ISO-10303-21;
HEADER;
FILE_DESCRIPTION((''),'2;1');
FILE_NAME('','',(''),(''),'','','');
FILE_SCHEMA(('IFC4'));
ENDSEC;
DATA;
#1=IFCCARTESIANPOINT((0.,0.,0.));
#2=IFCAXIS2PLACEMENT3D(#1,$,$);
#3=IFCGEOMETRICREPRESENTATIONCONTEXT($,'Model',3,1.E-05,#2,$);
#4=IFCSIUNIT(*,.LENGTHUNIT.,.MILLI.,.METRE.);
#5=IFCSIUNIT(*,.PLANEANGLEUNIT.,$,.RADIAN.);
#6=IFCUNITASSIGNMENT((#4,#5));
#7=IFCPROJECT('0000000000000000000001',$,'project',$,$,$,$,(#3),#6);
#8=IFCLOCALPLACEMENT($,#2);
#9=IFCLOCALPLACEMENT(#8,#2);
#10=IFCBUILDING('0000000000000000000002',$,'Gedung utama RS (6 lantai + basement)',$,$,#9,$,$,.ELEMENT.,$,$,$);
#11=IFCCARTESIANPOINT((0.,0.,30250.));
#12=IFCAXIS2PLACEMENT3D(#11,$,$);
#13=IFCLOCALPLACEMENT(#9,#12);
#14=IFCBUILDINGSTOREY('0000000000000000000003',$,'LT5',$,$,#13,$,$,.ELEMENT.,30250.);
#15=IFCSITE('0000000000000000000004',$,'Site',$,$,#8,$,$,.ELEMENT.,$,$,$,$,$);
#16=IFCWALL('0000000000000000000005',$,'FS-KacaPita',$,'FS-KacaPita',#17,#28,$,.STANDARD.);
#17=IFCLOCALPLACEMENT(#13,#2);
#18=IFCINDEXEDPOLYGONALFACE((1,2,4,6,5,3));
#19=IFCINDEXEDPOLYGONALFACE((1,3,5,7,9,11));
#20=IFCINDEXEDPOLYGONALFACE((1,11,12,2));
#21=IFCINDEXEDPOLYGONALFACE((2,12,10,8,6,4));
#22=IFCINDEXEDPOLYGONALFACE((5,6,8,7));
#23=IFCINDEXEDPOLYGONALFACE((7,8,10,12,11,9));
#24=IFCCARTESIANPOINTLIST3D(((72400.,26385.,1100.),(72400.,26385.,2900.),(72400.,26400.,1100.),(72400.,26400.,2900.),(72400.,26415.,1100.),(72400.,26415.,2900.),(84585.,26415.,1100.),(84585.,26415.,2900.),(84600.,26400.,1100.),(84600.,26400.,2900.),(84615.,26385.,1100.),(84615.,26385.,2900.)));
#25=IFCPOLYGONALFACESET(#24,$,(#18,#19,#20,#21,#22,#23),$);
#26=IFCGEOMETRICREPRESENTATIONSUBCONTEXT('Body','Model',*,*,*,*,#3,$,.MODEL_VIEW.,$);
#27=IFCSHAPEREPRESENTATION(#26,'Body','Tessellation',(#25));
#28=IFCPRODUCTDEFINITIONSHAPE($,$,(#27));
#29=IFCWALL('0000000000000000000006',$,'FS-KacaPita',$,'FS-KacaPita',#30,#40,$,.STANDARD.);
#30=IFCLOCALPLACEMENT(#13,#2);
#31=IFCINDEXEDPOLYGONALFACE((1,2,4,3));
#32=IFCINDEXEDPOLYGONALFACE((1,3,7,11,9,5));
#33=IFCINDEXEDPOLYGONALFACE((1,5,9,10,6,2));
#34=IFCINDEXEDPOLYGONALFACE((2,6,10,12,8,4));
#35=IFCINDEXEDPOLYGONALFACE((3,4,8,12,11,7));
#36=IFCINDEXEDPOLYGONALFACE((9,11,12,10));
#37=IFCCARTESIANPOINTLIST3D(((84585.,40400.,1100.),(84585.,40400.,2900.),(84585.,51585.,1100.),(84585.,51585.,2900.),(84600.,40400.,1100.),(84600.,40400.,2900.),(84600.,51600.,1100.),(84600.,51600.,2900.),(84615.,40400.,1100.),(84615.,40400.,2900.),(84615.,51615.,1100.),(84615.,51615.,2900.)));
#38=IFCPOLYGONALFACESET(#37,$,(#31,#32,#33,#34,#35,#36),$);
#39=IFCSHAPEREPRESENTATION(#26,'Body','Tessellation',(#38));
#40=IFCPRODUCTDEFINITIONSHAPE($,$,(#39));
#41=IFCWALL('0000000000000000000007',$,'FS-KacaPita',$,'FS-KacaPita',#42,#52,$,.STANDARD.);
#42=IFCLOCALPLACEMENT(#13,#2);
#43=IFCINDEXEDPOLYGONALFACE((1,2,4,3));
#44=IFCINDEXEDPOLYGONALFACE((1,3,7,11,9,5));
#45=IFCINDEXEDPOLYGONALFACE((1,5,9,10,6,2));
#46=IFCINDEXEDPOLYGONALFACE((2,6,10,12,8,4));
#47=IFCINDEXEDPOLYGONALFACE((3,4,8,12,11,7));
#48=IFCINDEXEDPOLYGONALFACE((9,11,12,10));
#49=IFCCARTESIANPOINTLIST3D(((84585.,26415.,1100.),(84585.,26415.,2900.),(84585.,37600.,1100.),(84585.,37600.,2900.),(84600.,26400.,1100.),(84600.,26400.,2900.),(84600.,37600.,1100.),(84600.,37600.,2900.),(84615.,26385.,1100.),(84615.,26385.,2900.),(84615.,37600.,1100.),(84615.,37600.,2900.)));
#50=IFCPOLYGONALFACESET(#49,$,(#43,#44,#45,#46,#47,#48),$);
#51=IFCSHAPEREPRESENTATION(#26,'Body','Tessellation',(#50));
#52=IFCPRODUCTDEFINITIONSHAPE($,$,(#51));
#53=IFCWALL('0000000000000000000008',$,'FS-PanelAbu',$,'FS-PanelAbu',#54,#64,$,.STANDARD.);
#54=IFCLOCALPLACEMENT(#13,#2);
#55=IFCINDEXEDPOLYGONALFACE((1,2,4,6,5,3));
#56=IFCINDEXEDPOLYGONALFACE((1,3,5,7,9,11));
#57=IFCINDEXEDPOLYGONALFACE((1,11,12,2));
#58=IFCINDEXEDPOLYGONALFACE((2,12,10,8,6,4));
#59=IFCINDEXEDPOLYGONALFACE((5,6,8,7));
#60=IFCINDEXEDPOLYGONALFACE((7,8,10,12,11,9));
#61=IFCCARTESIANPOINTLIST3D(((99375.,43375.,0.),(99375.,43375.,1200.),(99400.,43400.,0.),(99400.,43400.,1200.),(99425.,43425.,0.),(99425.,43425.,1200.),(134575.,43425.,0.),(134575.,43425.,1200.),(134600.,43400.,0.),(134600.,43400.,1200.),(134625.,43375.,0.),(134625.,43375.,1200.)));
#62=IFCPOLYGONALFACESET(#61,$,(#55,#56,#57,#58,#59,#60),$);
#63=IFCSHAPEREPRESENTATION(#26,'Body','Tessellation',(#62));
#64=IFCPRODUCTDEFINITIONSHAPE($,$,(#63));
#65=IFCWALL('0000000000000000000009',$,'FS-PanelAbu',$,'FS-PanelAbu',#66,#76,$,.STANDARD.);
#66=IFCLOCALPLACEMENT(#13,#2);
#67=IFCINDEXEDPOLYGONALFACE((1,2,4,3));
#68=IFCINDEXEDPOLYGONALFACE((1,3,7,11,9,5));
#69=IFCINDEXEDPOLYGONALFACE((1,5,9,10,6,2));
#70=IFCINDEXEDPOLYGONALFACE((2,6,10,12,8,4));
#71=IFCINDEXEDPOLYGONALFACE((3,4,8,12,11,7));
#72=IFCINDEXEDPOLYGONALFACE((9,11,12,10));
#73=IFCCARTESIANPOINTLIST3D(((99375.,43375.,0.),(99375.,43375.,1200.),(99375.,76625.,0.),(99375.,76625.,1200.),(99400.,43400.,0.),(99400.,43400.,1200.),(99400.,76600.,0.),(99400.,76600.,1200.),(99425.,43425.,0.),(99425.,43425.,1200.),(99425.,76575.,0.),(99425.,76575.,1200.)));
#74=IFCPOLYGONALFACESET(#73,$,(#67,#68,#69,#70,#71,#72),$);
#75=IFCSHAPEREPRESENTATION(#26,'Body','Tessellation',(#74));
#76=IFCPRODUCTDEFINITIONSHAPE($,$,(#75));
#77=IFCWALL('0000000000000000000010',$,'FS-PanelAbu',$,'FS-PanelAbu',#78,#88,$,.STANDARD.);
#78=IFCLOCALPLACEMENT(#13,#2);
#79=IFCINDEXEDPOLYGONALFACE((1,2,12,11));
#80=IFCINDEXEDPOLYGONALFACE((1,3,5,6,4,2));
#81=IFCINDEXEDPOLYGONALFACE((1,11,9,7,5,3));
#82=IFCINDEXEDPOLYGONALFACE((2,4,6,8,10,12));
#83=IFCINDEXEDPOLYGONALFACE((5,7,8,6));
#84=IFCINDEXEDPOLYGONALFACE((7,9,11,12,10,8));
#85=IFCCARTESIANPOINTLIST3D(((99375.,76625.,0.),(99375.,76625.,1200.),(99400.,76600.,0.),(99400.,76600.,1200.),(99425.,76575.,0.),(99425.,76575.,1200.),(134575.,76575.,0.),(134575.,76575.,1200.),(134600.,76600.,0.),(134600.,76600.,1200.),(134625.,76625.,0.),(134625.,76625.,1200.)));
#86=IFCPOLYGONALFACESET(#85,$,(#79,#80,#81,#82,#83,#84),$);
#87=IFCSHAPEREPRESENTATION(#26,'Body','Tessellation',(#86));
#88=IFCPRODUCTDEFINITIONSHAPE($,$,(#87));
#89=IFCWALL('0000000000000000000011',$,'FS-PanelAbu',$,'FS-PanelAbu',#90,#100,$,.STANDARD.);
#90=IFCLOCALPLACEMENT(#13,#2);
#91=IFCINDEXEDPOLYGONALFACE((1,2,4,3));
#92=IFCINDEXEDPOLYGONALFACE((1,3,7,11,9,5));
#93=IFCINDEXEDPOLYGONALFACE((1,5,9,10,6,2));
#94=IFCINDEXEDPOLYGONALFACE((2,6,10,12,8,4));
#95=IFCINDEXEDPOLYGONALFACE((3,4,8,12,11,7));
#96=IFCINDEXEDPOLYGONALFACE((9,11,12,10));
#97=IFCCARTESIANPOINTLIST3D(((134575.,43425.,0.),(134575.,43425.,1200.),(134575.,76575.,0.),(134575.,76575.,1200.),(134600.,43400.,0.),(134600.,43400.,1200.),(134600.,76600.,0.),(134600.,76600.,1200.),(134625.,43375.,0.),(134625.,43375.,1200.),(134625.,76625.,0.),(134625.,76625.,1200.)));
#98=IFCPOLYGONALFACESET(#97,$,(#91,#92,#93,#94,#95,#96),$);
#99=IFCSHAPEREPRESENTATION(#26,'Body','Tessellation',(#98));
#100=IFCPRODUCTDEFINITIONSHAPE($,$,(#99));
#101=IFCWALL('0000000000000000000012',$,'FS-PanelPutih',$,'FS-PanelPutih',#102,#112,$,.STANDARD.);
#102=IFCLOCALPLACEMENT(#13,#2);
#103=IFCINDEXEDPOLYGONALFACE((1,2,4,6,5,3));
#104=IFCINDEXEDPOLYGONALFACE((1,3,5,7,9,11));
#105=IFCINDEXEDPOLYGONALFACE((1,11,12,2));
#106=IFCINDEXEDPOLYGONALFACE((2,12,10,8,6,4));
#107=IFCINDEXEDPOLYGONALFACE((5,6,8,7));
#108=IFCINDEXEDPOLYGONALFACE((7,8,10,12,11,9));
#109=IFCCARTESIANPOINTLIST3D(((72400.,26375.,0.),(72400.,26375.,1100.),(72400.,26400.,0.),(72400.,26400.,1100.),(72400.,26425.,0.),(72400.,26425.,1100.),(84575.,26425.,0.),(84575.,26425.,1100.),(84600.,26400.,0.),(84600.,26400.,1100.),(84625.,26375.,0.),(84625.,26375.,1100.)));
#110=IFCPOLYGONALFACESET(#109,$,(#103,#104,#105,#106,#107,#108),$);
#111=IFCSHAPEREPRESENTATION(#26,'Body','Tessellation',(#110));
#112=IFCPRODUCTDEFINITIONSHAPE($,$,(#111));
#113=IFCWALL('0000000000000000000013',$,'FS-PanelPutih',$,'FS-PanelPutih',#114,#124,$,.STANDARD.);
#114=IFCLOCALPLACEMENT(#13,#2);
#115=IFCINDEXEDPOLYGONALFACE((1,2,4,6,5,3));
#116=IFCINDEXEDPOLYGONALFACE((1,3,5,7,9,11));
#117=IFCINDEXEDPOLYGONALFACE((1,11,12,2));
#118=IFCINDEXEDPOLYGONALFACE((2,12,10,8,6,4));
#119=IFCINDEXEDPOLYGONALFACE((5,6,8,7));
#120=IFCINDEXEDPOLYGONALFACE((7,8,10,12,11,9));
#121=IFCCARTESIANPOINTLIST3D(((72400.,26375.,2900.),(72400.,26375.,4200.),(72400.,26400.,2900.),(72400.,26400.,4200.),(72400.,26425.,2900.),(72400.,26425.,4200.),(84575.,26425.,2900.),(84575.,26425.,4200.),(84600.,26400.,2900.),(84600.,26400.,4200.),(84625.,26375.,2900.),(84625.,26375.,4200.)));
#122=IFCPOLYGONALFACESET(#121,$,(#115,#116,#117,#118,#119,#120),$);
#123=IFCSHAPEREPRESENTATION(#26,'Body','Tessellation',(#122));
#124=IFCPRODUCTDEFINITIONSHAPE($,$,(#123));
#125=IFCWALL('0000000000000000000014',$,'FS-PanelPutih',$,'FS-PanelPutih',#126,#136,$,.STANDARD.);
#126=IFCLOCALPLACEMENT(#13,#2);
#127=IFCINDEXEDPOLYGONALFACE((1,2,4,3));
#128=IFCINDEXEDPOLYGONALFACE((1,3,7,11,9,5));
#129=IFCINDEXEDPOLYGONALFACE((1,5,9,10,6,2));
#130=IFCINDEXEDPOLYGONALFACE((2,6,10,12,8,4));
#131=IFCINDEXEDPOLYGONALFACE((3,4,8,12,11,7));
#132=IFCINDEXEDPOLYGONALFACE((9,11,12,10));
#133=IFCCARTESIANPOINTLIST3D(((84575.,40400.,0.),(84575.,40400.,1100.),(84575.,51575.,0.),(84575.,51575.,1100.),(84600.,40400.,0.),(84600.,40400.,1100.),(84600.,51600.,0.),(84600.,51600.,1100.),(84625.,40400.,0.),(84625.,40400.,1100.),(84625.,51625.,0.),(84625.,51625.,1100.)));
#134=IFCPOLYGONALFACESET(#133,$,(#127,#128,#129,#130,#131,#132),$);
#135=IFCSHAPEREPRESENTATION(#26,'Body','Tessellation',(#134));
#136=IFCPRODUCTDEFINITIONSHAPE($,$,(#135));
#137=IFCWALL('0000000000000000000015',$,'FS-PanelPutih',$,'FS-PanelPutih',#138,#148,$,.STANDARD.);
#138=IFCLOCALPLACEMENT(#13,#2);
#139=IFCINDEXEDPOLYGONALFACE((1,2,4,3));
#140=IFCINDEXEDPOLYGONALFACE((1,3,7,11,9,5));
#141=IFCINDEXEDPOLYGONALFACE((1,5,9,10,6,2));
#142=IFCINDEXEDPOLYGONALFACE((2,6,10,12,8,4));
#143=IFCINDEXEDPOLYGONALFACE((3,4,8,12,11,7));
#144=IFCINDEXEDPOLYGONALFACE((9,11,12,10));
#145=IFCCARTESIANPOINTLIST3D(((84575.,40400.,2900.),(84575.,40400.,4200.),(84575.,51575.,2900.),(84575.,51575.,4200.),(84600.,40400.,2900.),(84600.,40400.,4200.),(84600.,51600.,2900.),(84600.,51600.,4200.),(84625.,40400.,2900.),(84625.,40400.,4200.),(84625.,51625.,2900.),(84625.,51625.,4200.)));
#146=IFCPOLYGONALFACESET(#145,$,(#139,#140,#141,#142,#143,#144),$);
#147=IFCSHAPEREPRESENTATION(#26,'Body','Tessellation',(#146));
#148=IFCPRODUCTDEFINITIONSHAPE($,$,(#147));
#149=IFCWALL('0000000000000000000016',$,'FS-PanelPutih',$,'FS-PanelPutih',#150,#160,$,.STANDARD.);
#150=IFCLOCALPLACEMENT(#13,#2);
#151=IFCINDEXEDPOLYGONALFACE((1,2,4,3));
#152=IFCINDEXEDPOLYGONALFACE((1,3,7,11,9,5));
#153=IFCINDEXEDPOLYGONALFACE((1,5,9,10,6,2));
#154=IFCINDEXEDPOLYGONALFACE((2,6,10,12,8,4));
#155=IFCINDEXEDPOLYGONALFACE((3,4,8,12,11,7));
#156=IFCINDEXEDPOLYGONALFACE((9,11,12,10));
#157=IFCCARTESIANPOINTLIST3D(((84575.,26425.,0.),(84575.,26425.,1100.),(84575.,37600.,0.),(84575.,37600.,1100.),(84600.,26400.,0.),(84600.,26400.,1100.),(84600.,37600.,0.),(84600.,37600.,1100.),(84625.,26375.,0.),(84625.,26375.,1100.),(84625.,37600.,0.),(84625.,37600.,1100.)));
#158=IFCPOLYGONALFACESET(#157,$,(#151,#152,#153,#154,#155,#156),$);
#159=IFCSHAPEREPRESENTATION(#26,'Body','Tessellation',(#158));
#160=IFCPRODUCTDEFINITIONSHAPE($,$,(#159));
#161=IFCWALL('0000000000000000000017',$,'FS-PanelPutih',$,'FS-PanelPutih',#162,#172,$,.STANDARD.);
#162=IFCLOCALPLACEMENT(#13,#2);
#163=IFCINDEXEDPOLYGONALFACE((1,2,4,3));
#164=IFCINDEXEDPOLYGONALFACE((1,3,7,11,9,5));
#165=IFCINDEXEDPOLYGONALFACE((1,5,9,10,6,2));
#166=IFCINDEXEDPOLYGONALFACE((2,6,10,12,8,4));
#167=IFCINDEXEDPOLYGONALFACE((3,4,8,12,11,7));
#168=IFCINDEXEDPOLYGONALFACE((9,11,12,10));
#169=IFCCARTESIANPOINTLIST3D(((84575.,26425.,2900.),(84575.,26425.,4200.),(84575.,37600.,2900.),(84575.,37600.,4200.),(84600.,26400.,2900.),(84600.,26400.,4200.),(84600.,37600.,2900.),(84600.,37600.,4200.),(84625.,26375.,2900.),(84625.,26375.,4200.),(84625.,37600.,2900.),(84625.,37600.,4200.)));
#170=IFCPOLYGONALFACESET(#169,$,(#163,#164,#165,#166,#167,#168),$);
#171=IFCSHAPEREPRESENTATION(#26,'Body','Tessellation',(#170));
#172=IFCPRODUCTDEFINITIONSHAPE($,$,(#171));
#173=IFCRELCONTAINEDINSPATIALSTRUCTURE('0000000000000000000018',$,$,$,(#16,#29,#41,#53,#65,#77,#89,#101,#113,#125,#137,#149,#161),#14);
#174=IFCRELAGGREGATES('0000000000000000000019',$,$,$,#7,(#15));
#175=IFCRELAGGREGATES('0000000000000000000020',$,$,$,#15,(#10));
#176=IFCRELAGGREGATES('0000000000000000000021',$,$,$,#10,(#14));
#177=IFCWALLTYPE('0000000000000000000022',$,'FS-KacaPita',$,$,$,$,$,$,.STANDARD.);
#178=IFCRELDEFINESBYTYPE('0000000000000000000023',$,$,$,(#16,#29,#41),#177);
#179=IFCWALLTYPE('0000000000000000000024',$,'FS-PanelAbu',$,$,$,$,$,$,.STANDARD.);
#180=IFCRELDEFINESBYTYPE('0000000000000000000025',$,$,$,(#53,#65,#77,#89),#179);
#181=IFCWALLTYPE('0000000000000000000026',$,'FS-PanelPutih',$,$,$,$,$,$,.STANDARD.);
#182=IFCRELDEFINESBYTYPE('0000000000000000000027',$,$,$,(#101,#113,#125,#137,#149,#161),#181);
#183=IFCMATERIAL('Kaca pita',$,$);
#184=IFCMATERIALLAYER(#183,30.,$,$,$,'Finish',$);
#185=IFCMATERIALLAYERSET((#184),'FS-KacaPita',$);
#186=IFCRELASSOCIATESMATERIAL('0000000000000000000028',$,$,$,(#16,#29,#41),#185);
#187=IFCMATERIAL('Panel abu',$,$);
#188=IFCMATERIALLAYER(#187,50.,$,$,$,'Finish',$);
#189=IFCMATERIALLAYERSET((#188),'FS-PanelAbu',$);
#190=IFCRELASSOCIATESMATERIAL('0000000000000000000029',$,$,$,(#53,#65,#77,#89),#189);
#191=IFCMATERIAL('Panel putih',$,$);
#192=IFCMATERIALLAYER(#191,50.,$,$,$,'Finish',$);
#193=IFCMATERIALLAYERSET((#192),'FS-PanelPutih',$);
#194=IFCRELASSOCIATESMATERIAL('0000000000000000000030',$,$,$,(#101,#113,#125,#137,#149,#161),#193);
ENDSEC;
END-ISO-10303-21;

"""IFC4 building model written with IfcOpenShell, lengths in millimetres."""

from ifc_helpers import new_model, si_unit, frame, origin, place, context, subcontext, project, spatial, polyline, outline, extrude, material, layer, layer_set, layer_usage, type_object, element, save


model = new_model("IFC4")

# Units and contexts
model_context = context("Model", 3, precision=1e-05, world=origin())
body_context = subcontext(model_context, "Body", "Model", "MODEL_VIEW")
ifc_project = project(units=[si_unit("LENGTHUNIT", "METRE", prefix="MILLI"), si_unit("PLANEANGLEUNIT", "RADIAN")], contexts=[model_context])

# Site, building, storey
site_placement = place(None, origin())
site = spatial("IfcSite", under=ifc_project, at=site_placement, Name="Site", CompositionType="ELEMENT")
building_placement = place(site_placement, origin())
building = spatial("IfcBuilding", under=site, at=building_placement, Name="Gedung utama RS (6 lantai + basement)", CompositionType="ELEMENT")
storey_placement = place(building_placement, frame((0.0, 0.0, 30250.0)))
storey = spatial("IfcBuildingStorey", under=building, at=storey_placement, Name="LT5", CompositionType="ELEMENT", Elevation=30250.0)

# Walls
ifc_material_1 = material(Name="Kaca pita")
ifc_layer_1 = layer(ifc_material_1, 30.0, Category="Finish")
ifc_layer_set_1 = layer_set([ifc_layer_1], Name="FS-KacaPita")
ifc_layer_usage_1 = layer_usage(ifc_layer_set_1, "AXIS2", "NEGATIVE", 15.0)
wall_type_1 = type_object("IfcWallType", Name="FS-KacaPita", PredefinedType="STANDARD")
wall_1_placement = place(storey_placement, frame((84600.0, 26400.0, 1100.0), z_axis=(0.0, 0.0, 1.0), x_axis=(-1.0, 0.0, 0.0)))
element("IfcWall", 1, at=wall_1_placement, inside=storey, type_object=wall_type_1, material=ifc_layer_usage_1, Name="FS-KacaPita", ObjectType="FS-KacaPita", PredefinedType="STANDARD", context=body_context, shape_type="SweptSolid", body=[
    extrude(outline(polyline([(15.0, -15.0), (0.0, 0.0), (-15.0, 15.0), (12200.0, 15.0), (12200.0, 0.0), (12200.0, -15.0), (15.0, -15.0)])), origin(), (0.0, 0.0, 1.0), 1800.0),
])
wall_2_placement = place(storey_placement, frame((84600.0, 51600.0, 1100.0), z_axis=(0.0, 0.0, 1.0), x_axis=(0.0, -1.0, 0.0)))
element("IfcWall", 2, at=wall_2_placement, inside=storey, type_object=wall_type_1, material=ifc_layer_usage_1, Name="FS-KacaPita", ObjectType="FS-KacaPita", PredefinedType="STANDARD", context=body_context, shape_type="SweptSolid", body=[
    extrude(outline(polyline([(15.0, -15.0), (0.0, 0.0), (-15.0, 15.0), (11200.0, 15.0), (11200.0, 0.0), (11200.0, -15.0), (15.0, -15.0)])), origin(), (0.0, 0.0, 1.0), 1800.0),
])
wall_3_placement = place(storey_placement, frame((84600.0, 37600.0, 1100.0), z_axis=(0.0, 0.0, 1.0), x_axis=(0.0, -1.0, 0.0)))
element("IfcWall", 3, at=wall_3_placement, inside=storey, type_object=wall_type_1, material=ifc_layer_usage_1, Name="FS-KacaPita", ObjectType="FS-KacaPita", PredefinedType="STANDARD", context=body_context, shape_type="SweptSolid", body=[
    extrude(outline(polyline([(0.0, -15.0), (0.0, 0.0), (0.0, 15.0), (11215.0, 15.0), (11200.0, 0.0), (11185.0, -15.0), (0.0, -15.0)])), origin(), (0.0, 0.0, 1.0), 1800.0),
])
ifc_material_2 = material(Name="Panel abu")
ifc_layer_2 = layer(ifc_material_2, 50.0, Category="Finish")
ifc_layer_set_2 = layer_set([ifc_layer_2], Name="FS-PanelAbu")
ifc_layer_usage_2 = layer_usage(ifc_layer_set_2, "AXIS2", "NEGATIVE", 25.0)
wall_type_2 = type_object("IfcWallType", Name="FS-PanelAbu", PredefinedType="STANDARD")
wall_4_placement = place(storey_placement, frame((134600.0, 43400.0, 0.0), z_axis=(0.0, 0.0, 1.0), x_axis=(-1.0, 0.0, 0.0)))
element("IfcWall", 4, at=wall_4_placement, inside=storey, type_object=wall_type_2, material=ifc_layer_usage_2, Name="FS-PanelAbu", ObjectType="FS-PanelAbu", PredefinedType="STANDARD", context=body_context, shape_type="SweptSolid", body=[
    extrude(outline(polyline([(25.0, -25.0), (0.0, 0.0), (-25.0, 25.0), (35225.0, 25.0), (35200.0, 0.0), (35175.0, -25.0), (25.0, -25.0)])), origin(), (0.0, 0.0, 1.0), 1200.0),
])
wall_5_placement = place(storey_placement, frame((99400.0, 43400.0, 0.0), z_axis=(0.0, 0.0, 1.0), x_axis=(0.0, 1.0, 0.0)))
element("IfcWall", 5, at=wall_5_placement, inside=storey, type_object=wall_type_2, material=ifc_layer_usage_2, Name="FS-PanelAbu", ObjectType="FS-PanelAbu", PredefinedType="STANDARD", context=body_context, shape_type="SweptSolid", body=[
    extrude(outline(polyline([(25.0, -25.0), (0.0, 0.0), (-25.0, 25.0), (33225.0, 25.0), (33200.0, 0.0), (33175.0, -25.0), (25.0, -25.0)])), origin(), (0.0, 0.0, 1.0), 1200.0),
])
wall_6_placement = place(storey_placement, frame((99400.0, 76600.0, 0.0), z_axis=(0.0, 0.0, 1.0), x_axis=(1.0, 0.0, 0.0)))
element("IfcWall", 6, at=wall_6_placement, inside=storey, type_object=wall_type_2, material=ifc_layer_usage_2, Name="FS-PanelAbu", ObjectType="FS-PanelAbu", PredefinedType="STANDARD", context=body_context, shape_type="SweptSolid", body=[
    extrude(outline(polyline([(25.0, -25.0), (0.0, 0.0), (-25.0, 25.0), (35225.0, 25.0), (35200.0, 0.0), (35175.0, -25.0), (25.0, -25.0)])), origin(), (0.0, 0.0, 1.0), 1200.0),
])
wall_7_placement = place(storey_placement, frame((134600.0, 76600.0, 0.0), z_axis=(0.0, 0.0, 1.0), x_axis=(0.0, -1.0, 0.0)))
element("IfcWall", 7, at=wall_7_placement, inside=storey, type_object=wall_type_2, material=ifc_layer_usage_2, Name="FS-PanelAbu", ObjectType="FS-PanelAbu", PredefinedType="STANDARD", context=body_context, shape_type="SweptSolid", body=[
    extrude(outline(polyline([(25.0, -25.0), (0.0, 0.0), (-25.0, 25.0), (33225.0, 25.0), (33200.0, 0.0), (33175.0, -25.0), (25.0, -25.0)])), origin(), (0.0, 0.0, 1.0), 1200.0),
])
ifc_material_3 = material(Name="Panel putih")
ifc_layer_3 = layer(ifc_material_3, 50.0, Category="Finish")
ifc_layer_set_3 = layer_set([ifc_layer_3], Name="FS-PanelPutih")
ifc_layer_usage_3 = layer_usage(ifc_layer_set_3, "AXIS2", "NEGATIVE", 25.0)
wall_type_3 = type_object("IfcWallType", Name="FS-PanelPutih", PredefinedType="STANDARD")
wall_8_placement = place(storey_placement, frame((84600.0, 26400.0, 0.0), z_axis=(0.0, 0.0, 1.0), x_axis=(-1.0, 0.0, 0.0)))
element("IfcWall", 8, at=wall_8_placement, inside=storey, type_object=wall_type_3, material=ifc_layer_usage_3, Name="FS-PanelPutih", ObjectType="FS-PanelPutih", PredefinedType="STANDARD", context=body_context, shape_type="SweptSolid", body=[
    extrude(outline(polyline([(25.0, -25.0), (0.0, 0.0), (-25.0, 25.0), (12200.0, 25.0), (12200.0, 0.0), (12200.0, -25.0), (25.0, -25.0)])), origin(), (0.0, 0.0, 1.0), 1100.0),
])
wall_9_placement = place(storey_placement, frame((84600.0, 26400.0, 2900.0), z_axis=(0.0, 0.0, 1.0), x_axis=(-1.0, 0.0, 0.0)))
element("IfcWall", 9, at=wall_9_placement, inside=storey, type_object=wall_type_3, material=ifc_layer_usage_3, Name="FS-PanelPutih", ObjectType="FS-PanelPutih", PredefinedType="STANDARD", context=body_context, shape_type="SweptSolid", body=[
    extrude(outline(polyline([(25.0, -25.0), (0.0, 0.0), (-25.0, 25.0), (12200.0, 25.0), (12200.0, 0.0), (12200.0, -25.0), (25.0, -25.0)])), origin(), (0.0, 0.0, 1.0), 1300.0),
])
wall_10_placement = place(storey_placement, frame((84600.0, 51600.0, 0.0), z_axis=(0.0, 0.0, 1.0), x_axis=(0.0, -1.0, 0.0)))
element("IfcWall", 10, at=wall_10_placement, inside=storey, type_object=wall_type_3, material=ifc_layer_usage_3, Name="FS-PanelPutih", ObjectType="FS-PanelPutih", PredefinedType="STANDARD", context=body_context, shape_type="SweptSolid", body=[
    extrude(outline(polyline([(25.0, -25.0), (0.0, 0.0), (-25.0, 25.0), (11200.0, 25.0), (11200.0, 0.0), (11200.0, -25.0), (25.0, -25.0)])), origin(), (0.0, 0.0, 1.0), 1100.0),
])
wall_11_placement = place(storey_placement, frame((84600.0, 51600.0, 2900.0), z_axis=(0.0, 0.0, 1.0), x_axis=(0.0, -1.0, 0.0)))
element("IfcWall", 11, at=wall_11_placement, inside=storey, type_object=wall_type_3, material=ifc_layer_usage_3, Name="FS-PanelPutih", ObjectType="FS-PanelPutih", PredefinedType="STANDARD", context=body_context, shape_type="SweptSolid", body=[
    extrude(outline(polyline([(25.0, -25.0), (0.0, 0.0), (-25.0, 25.0), (11200.0, 25.0), (11200.0, 0.0), (11200.0, -25.0), (25.0, -25.0)])), origin(), (0.0, 0.0, 1.0), 1300.0),
])
wall_12_placement = place(storey_placement, frame((84600.0, 37600.0, 0.0), z_axis=(0.0, 0.0, 1.0), x_axis=(0.0, -1.0, 0.0)))
element("IfcWall", 12, at=wall_12_placement, inside=storey, type_object=wall_type_3, material=ifc_layer_usage_3, Name="FS-PanelPutih", ObjectType="FS-PanelPutih", PredefinedType="STANDARD", context=body_context, shape_type="SweptSolid", body=[
    extrude(outline(polyline([(0.0, -25.0), (0.0, 0.0), (0.0, 25.0), (11225.0, 25.0), (11200.0, 0.0), (11175.0, -25.0), (0.0, -25.0)])), origin(), (0.0, 0.0, 1.0), 1100.0),
])
wall_13_placement = place(storey_placement, frame((84600.0, 37600.0, 2900.0), z_axis=(0.0, 0.0, 1.0), x_axis=(0.0, -1.0, 0.0)))
element("IfcWall", 13, at=wall_13_placement, inside=storey, type_object=wall_type_3, material=ifc_layer_usage_3, Name="FS-PanelPutih", ObjectType="FS-PanelPutih", PredefinedType="STANDARD", context=body_context, shape_type="SweptSolid", body=[
    extrude(outline(polyline([(0.0, -25.0), (0.0, 0.0), (0.0, 25.0), (11225.0, 25.0), (11200.0, 0.0), (11175.0, -25.0), (0.0, -25.0)])), origin(), (0.0, 0.0, 1.0), 1300.0),
])

save(model, "model.ifc")
